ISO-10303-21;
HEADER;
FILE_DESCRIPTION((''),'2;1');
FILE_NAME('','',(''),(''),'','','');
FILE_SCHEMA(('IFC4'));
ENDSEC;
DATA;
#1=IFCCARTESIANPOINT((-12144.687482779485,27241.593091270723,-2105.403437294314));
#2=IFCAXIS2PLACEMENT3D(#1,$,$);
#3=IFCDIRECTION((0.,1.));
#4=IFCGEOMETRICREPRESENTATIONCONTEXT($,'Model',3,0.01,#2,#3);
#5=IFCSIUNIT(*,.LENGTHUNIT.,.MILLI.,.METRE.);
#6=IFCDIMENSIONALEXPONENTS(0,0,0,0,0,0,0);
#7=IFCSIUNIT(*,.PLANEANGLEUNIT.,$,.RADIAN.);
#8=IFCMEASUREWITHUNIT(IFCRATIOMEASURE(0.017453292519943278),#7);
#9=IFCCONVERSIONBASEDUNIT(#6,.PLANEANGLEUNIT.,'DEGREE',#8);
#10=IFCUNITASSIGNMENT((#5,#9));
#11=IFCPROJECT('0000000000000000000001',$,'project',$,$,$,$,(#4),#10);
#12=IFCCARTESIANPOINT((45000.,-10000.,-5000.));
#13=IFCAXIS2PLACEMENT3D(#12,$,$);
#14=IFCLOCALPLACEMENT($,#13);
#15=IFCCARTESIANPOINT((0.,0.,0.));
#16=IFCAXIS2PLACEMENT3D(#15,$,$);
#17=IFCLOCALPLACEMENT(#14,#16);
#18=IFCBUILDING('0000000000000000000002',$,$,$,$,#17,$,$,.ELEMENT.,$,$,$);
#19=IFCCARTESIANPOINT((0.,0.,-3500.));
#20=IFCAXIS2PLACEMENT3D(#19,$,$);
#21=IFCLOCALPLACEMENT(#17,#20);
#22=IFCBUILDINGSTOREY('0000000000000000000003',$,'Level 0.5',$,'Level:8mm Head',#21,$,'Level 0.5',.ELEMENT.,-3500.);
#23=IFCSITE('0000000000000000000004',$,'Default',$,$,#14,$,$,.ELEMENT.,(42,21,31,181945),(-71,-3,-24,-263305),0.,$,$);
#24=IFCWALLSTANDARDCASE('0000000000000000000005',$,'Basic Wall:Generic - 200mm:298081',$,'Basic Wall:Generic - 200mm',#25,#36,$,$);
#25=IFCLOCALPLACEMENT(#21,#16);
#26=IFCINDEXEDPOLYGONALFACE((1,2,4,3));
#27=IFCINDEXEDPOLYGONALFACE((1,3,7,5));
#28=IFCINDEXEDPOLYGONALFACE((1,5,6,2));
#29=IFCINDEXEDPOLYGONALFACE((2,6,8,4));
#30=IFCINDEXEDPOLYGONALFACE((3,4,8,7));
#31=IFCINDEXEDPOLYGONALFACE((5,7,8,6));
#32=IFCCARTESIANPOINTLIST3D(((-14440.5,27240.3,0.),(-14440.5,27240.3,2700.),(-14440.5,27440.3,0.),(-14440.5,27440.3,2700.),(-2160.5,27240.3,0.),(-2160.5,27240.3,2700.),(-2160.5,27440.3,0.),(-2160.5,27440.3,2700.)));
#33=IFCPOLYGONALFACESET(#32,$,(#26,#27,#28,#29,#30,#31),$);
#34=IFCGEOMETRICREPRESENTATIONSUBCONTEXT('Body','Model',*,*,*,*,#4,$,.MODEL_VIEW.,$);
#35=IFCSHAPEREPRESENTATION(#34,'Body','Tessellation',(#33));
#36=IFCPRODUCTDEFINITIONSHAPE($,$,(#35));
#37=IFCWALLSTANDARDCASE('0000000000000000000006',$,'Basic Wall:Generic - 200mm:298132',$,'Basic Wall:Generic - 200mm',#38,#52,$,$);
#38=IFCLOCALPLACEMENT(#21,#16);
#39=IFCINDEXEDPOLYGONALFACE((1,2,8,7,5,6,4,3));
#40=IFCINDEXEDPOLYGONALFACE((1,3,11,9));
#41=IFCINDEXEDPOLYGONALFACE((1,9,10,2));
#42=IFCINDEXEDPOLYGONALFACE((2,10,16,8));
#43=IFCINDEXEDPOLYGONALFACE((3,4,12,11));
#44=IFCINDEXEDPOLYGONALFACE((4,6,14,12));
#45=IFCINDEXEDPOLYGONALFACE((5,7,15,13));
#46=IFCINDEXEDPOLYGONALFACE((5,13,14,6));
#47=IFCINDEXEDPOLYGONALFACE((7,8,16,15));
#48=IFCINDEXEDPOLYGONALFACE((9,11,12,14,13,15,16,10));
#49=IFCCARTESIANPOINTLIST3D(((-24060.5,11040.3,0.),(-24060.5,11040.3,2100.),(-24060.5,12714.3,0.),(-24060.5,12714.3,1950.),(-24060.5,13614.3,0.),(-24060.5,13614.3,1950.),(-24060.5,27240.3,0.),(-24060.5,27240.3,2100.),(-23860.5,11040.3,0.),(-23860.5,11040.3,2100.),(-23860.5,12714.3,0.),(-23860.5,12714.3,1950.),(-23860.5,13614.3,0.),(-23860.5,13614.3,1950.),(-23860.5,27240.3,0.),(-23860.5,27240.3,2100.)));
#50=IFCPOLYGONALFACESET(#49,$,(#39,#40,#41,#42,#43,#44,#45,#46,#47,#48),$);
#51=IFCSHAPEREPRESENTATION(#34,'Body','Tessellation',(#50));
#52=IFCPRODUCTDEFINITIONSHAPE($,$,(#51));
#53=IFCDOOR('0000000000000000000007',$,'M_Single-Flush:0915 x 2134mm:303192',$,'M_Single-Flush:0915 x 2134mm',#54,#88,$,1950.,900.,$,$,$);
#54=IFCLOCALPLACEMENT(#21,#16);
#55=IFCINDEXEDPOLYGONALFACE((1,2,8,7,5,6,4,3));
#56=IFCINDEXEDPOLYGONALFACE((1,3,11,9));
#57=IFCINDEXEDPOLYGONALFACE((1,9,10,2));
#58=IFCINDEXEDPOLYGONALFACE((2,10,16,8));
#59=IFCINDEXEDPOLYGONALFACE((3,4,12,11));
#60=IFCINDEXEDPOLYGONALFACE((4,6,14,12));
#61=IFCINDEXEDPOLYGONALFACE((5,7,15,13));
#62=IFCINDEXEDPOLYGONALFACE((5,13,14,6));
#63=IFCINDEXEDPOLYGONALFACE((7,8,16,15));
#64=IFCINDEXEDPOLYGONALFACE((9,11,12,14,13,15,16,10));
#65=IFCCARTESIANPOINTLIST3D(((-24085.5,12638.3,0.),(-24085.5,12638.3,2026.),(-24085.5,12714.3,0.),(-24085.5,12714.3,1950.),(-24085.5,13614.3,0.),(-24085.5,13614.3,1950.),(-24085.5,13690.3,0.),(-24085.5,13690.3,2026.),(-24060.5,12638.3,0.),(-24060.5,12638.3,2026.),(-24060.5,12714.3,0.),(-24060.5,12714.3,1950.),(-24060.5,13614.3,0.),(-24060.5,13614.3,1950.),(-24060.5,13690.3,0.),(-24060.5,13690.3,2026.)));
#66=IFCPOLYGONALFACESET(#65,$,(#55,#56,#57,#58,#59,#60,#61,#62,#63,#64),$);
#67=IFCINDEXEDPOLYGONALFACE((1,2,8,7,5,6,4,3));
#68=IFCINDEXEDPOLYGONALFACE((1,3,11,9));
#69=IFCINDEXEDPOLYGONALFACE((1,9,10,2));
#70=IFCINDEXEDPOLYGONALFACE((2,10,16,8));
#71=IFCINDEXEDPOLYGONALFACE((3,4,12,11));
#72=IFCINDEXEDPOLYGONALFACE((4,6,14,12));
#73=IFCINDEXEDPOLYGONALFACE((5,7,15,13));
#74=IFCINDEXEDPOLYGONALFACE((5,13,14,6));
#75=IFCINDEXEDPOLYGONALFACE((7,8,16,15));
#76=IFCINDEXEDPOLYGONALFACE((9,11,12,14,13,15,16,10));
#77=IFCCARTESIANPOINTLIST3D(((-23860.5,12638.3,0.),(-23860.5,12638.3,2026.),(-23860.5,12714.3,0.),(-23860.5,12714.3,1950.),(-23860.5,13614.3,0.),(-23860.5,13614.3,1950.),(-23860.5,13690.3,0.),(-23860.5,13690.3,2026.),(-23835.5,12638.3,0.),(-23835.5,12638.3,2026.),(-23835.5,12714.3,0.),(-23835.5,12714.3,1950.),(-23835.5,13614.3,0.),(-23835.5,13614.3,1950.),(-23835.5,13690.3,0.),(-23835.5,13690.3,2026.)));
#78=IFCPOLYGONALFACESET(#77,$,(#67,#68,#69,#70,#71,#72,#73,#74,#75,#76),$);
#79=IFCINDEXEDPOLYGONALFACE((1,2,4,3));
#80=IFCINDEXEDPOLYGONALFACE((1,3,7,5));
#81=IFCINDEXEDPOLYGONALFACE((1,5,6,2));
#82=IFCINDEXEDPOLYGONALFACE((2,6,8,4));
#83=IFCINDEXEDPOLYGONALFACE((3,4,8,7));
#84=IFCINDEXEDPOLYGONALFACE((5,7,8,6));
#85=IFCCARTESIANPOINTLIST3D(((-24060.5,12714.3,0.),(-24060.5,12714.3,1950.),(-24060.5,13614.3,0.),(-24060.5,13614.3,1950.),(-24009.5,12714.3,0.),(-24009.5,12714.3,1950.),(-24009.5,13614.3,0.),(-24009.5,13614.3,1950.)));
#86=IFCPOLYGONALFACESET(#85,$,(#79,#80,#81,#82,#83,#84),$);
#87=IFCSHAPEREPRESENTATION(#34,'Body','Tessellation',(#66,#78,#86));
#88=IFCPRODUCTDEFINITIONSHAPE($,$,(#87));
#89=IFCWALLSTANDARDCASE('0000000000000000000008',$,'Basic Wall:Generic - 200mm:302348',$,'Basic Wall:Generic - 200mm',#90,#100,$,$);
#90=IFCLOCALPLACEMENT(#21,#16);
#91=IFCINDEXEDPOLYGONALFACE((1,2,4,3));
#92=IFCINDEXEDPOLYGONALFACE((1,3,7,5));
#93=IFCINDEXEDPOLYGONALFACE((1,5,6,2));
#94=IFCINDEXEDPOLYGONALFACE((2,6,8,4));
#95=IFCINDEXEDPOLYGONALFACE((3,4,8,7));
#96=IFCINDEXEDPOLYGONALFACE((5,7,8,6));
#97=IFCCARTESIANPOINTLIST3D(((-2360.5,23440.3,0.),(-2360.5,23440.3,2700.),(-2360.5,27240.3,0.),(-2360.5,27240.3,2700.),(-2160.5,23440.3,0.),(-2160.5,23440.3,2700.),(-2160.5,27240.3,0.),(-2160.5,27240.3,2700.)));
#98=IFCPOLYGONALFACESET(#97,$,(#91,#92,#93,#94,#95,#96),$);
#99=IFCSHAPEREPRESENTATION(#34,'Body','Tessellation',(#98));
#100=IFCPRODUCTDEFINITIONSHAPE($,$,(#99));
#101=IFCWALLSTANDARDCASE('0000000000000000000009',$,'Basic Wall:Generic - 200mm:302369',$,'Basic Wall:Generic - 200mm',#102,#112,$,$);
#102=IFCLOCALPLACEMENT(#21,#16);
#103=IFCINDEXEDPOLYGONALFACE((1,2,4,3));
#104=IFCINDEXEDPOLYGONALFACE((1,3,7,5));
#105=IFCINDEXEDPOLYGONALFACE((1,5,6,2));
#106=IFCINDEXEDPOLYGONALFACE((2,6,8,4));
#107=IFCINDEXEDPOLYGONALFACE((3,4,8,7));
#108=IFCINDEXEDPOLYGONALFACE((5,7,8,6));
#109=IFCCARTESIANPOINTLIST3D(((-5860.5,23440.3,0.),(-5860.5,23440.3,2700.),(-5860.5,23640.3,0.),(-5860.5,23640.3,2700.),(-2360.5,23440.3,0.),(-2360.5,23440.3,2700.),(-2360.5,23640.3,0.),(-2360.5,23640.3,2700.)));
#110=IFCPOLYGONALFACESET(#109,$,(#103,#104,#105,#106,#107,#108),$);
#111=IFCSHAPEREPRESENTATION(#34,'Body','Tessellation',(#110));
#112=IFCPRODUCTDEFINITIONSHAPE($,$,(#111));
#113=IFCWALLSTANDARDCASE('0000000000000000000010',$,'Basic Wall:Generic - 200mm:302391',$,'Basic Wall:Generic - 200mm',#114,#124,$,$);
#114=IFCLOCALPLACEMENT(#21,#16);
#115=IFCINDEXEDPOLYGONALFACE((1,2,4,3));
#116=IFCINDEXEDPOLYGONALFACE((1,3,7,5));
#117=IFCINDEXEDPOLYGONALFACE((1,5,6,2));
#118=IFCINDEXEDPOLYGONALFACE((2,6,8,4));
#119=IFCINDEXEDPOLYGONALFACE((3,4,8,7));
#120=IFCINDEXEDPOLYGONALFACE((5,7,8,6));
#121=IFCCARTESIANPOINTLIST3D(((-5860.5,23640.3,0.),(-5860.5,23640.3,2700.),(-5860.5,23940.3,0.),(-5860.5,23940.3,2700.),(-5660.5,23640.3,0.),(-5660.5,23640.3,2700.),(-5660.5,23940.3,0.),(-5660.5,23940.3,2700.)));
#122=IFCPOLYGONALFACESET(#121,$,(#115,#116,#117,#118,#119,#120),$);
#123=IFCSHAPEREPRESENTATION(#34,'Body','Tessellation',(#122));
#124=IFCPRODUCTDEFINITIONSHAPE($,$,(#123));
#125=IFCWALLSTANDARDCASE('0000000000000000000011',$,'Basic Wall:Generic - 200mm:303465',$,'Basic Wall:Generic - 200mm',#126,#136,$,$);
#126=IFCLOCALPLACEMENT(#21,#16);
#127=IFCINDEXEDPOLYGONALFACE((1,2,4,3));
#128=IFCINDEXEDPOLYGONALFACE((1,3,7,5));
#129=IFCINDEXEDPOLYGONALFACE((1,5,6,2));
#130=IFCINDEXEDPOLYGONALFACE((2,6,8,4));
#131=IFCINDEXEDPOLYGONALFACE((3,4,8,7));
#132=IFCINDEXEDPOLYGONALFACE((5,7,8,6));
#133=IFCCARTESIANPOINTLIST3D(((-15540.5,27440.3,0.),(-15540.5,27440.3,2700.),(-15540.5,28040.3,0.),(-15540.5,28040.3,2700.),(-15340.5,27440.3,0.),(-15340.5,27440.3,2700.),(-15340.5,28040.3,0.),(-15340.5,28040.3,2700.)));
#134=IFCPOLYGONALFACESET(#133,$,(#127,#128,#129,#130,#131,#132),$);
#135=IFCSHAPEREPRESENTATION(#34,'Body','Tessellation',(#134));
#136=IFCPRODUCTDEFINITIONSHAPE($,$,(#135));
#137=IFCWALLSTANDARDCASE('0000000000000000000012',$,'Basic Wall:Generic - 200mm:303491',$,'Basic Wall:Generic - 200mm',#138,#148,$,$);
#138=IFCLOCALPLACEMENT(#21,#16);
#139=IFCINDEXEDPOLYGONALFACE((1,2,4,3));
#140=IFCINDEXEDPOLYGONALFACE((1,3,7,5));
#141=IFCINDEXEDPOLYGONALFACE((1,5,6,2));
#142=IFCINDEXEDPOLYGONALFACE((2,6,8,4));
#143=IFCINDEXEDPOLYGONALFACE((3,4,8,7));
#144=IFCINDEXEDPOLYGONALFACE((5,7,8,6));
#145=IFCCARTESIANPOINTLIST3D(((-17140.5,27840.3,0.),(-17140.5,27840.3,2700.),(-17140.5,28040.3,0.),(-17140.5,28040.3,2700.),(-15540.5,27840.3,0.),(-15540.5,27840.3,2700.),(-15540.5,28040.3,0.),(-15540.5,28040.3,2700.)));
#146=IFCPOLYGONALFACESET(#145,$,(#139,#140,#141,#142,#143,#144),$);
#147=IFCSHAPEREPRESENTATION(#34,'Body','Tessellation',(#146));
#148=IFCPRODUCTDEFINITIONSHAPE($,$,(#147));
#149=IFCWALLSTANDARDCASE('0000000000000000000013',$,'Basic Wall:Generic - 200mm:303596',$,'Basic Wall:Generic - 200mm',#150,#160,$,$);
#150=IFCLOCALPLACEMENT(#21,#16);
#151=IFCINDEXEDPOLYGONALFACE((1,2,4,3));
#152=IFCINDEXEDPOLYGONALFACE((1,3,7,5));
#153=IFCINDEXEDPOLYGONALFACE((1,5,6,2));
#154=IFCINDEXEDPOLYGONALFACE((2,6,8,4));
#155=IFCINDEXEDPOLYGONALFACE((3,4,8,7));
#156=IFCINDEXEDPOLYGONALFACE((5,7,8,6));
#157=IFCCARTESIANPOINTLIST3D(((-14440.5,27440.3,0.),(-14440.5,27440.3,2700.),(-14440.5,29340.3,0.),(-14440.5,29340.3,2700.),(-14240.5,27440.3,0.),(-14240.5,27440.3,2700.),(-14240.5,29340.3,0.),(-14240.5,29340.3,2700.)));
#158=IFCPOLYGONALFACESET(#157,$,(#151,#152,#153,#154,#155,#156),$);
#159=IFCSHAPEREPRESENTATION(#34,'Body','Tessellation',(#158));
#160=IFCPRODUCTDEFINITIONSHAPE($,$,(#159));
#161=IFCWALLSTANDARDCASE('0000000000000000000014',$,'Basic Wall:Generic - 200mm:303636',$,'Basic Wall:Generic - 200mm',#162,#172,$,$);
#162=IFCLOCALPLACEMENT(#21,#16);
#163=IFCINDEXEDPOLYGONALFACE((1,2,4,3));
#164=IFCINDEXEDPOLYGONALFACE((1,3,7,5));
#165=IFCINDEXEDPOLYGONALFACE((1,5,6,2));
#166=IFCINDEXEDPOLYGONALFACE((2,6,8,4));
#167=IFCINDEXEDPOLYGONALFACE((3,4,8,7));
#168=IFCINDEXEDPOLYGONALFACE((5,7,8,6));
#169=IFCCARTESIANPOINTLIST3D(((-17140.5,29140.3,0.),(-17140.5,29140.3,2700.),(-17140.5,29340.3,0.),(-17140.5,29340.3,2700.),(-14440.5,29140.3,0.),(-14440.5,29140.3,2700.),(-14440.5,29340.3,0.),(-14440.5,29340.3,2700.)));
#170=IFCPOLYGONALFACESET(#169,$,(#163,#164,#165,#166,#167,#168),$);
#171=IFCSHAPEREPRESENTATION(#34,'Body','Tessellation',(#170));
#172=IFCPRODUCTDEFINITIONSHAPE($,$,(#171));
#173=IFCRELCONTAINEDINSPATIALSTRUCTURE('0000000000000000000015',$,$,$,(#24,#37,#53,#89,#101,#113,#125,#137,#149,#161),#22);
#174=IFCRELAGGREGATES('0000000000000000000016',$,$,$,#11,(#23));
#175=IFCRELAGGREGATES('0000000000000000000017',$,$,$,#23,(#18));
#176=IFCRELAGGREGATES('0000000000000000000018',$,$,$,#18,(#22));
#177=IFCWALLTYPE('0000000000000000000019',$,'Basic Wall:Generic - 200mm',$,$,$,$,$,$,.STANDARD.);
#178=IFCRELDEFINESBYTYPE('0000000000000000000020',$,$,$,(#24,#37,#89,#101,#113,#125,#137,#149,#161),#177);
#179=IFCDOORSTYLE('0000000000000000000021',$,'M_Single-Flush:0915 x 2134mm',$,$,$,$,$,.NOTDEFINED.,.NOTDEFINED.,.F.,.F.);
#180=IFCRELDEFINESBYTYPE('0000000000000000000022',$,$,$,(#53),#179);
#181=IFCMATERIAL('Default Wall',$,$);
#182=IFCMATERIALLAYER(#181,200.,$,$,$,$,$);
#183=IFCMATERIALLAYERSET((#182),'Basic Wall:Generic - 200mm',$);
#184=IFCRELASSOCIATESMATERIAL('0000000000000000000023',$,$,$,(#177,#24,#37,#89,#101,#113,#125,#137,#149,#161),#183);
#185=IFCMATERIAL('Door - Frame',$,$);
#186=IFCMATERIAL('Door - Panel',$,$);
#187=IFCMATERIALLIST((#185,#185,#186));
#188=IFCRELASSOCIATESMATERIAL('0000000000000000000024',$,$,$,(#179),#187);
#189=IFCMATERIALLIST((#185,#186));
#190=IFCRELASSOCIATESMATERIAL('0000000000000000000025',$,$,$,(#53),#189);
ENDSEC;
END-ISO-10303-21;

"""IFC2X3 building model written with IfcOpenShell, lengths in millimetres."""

from ifc_helpers import new_model, entity, si_unit, converted_unit, direction, frame, frame_2d, origin, place, context, subcontext, project, spatial, polyline, rectangle, outline, extrude, clip, bounded_halfspace, source, transform, mapped, material, material_list, layer, layer_set, layer_usage, type_object, type_shapes, element, fill, save


model = new_model("IFC2X3")

# Units and contexts
model_context = context("Model", 3, precision=0.01, world=frame((-12144.687482779485, 27241.593091270723, -2105.403437294314)), true_north=direction((0.0, 1.0)))
body_context = subcontext(model_context, "Body", "Model", "MODEL_VIEW")
ifc_project = project(units=[si_unit("LENGTHUNIT", "METRE", prefix="MILLI"), converted_unit("PLANEANGLEUNIT", "DEGREE", entity("IfcRatioMeasure", 0.017453292519943278), si_unit("PLANEANGLEUNIT", "RADIAN"), dimensions=[0, 0, 0, 0, 0, 0, 0])], contexts=[model_context])

# Site, building, storey
site_placement = place(None, frame((45000.0, -10000.0, -5000.0)))
site = spatial("IfcSite", under=ifc_project, at=site_placement, Name="Default", CompositionType="ELEMENT", RefLatitude=(42, 21, 31, 181945), RefLongitude=(-71, -3, -24, -263305), RefElevation=0.0)
building_placement = place(site_placement, origin())
building = spatial("IfcBuilding", under=site, at=building_placement, CompositionType="ELEMENT")
storey_placement = place(building_placement, frame((0.0, 0.0, -3500.0)))
storey = spatial("IfcBuildingStorey", under=building, at=storey_placement, Name="Level 0.5", ObjectType="Level:8mm Head", LongName="Level 0.5", CompositionType="ELEMENT", Elevation=-3500.0)

# Wall
ifc_material_1 = material(Name="Default Wall")
ifc_layer_1 = layer(ifc_material_1, 200.0)
ifc_layer_set_1 = layer_set([ifc_layer_1], Name="Basic Wall:Generic - 200mm")
wall_type_1 = type_object("IfcWallType", Name="Basic Wall:Generic - 200mm", PredefinedType="STANDARD", material=ifc_layer_set_1)
ifc_layer_usage_1 = layer_usage(ifc_layer_set_1, "AXIS2", "NEGATIVE", 100.0)
wall_1_placement = place(storey_placement, frame((-2160.5, 27340.3, 0.0), z_axis=(0.0, 0.0, 1.0), x_axis=(-1.0, 0.0, 0.0)))
element("IfcWallStandardCase", 1, at=wall_1_placement, inside=storey, type_object=wall_type_1, material=ifc_layer_usage_1, Name="Basic Wall:Generic - 200mm:298081", ObjectType="Basic Wall:Generic - 200mm", context=body_context, shape_type="SweptSolid", body=[
    extrude(rectangle(XDim=12280.0, YDim=200.0, at=frame_2d((6140.0, 0.0), x_axis=(-1.0, 0.0))), origin(), (0.0, 0.0, 1.0), 2700.0),
])

# Wall, opening, door
ifc_layer_usage_2 = layer_usage(ifc_layer_set_1, "AXIS2", "NEGATIVE", 100.0)
wall_2_placement = place(storey_placement, frame((-23960.5, 27240.3, 0.0), z_axis=(0.0, 0.0, 1.0), x_axis=(0.0, -1.0, 0.0)))
wall_2 = element("IfcWallStandardCase", 2, at=wall_2_placement, inside=storey, type_object=wall_type_1, material=ifc_layer_usage_2, Name="Basic Wall:Generic - 200mm:298132", ObjectType="Basic Wall:Generic - 200mm", context=body_context, shape_type="Clipping", body=[
    clip(extrude(rectangle(XDim=16200.0, YDim=200.0, at=frame_2d((8100.0, 0.0), x_axis=(1.0, 0.0))), origin(), (0.0, 0.0, 1.0), 2100.0), bounded_halfspace(frame((0.0, -100.0, 2100.0), z_axis=(0.0, 0.0, -1.0), x_axis=(1.0, 0.0, 0.0)), True, frame((0.0, -100.0, 2100.0)), polyline([(0.0, 0.0), (4884716.1, 0.0), (4937760.0, 0.0), (4937760.0, 60960.0), (0.0, 60960.0), (0.0, 0.0)]))),
])
opening_1_placement = place(wall_2_placement, frame((14526.0, 100.0, 0.0)))
opening_1 = element("IfcOpeningElement", 3, at=opening_1_placement, cuts=wall_2, ObjectType="Opening", context=body_context, shape_type="SweptSolid", body=[
    extrude(rectangle(XDim=900.0, YDim=1950.0, at=frame_2d((975.0, 450.0), x_axis=(0.0, -1.0))), frame((0.0, 0.0, 0.0), z_axis=(0.0, -1.0, 0.0), x_axis=(0.0, 0.0, 1.0)), (0.0, 0.0, 1.0), 200.0),
])
ifc_material_2 = material(Name="Door - Frame")
ifc_material_3 = material(Name="Door - Panel")
ifc_material_list_1 = material_list([ifc_material_2, ifc_material_3])
ifc_material_list_2 = material_list([ifc_material_2, ifc_material_2, ifc_material_3])
door_style = type_object("IfcDoorStyle", Name="M_Single-Flush:0915 x 2134mm", ConstructionType="NOTDEFINED", OperationType="NOTDEFINED", ParameterTakesPrecedence=False, Sizeable=False, material=ifc_material_list_2)
shared_shape_1 = source(origin(), body_context, "Body", "SweptSolid", [
    extrude(outline(polyline([(-526.0, -1032.0), (526.0, -1032.0), (526.0, 994.0), (450.0, 994.0), (450.0, -956.0), (-450.0, -956.0), (-450.0, 994.0), (-526.0, 994.0), (-526.0, -1032.0)])), frame((450.0, 225.0, 994.0), z_axis=(0.0, -1.0, 0.0), x_axis=(-1.0, 0.0, 0.0)), (0.0, 0.0, 1.0), 25.0),
    extrude(outline(polyline([(-1032.0, -526.0), (994.0, -526.0), (994.0, -450.0), (-956.0, -450.0), (-956.0, 450.0), (994.0, 450.0), (994.0, 526.0), (-1032.0, 526.0), (-1032.0, -526.0)])), frame((450.0, 0.0, 994.0), z_axis=(0.0, -1.0, 0.0), x_axis=(0.0, 0.0, -1.0)), (0.0, 0.0, 1.0), 25.0),
    extrude(rectangle(XDim=900.0, YDim=51.0, at=frame_2d((0.0, 0.0), x_axis=(1.0, 0.0))), frame((450.0, 174.5, 0.0)), (0.0, 0.0, 1.0), 1950.0),
])
type_shapes(door_style, [shared_shape_1])
door_placement = place(opening_1_placement, frame((0.0, 0.0, 0.0), z_axis=(0.0, 0.0, 1.0), x_axis=(-1.0, 0.0, 0.0)))
door = element("IfcDoor", 4, at=door_placement, inside=storey, type_object=door_style, material=ifc_material_list_1, Name="M_Single-Flush:0915 x 2134mm:303192", ObjectType="M_Single-Flush:0915 x 2134mm", OverallHeight=1950.0, OverallWidth=900.0, context=body_context, shape_type="MappedRepresentation", body=[
    mapped(shared_shape_1, transform((0.0, 0.0, 0.0), scale=1.0)),
])
fill(opening_1, door)

# Walls
ifc_layer_usage_3 = layer_usage(ifc_layer_set_1, "AXIS2", "NEGATIVE", 100.0)
wall_3_placement = place(storey_placement, frame((-2260.5, 27240.3, 0.0), z_axis=(0.0, 0.0, 1.0), x_axis=(0.0, -1.0, 0.0)))
element("IfcWallStandardCase", 5, at=wall_3_placement, inside=storey, type_object=wall_type_1, material=ifc_layer_usage_3, Name="Basic Wall:Generic - 200mm:302348", ObjectType="Basic Wall:Generic - 200mm", context=body_context, shape_type="SweptSolid", body=[
    extrude(rectangle(XDim=3800.0, YDim=200.0, at=frame_2d((1900.0, 0.0), x_axis=(-1.0, 0.0))), origin(), (0.0, 0.0, 1.0), 2700.0),
])
ifc_layer_usage_4 = layer_usage(ifc_layer_set_1, "AXIS2", "NEGATIVE", 100.0)
wall_4_placement = place(storey_placement, frame((-2360.5, 23540.3, 0.0), z_axis=(0.0, 0.0, 1.0), x_axis=(-1.0, 0.0, 0.0)))
element("IfcWallStandardCase", 6, at=wall_4_placement, inside=storey, type_object=wall_type_1, material=ifc_layer_usage_4, Name="Basic Wall:Generic - 200mm:302369", ObjectType="Basic Wall:Generic - 200mm", context=body_context, shape_type="SweptSolid", body=[
    extrude(rectangle(XDim=3500.0, YDim=200.0, at=frame_2d((1750.0, 0.0), x_axis=(-1.0, 0.0))), origin(), (0.0, 0.0, 1.0), 2700.0),
])
ifc_layer_usage_5 = layer_usage(ifc_layer_set_1, "AXIS2", "NEGATIVE", 100.0)
wall_5_placement = place(storey_placement, frame((-5760.5, 23640.3, 0.0), z_axis=(0.0, 0.0, 1.0), x_axis=(0.0, 1.0, 0.0)))
element("IfcWallStandardCase", 7, at=wall_5_placement, inside=storey, type_object=wall_type_1, material=ifc_layer_usage_5, Name="Basic Wall:Generic - 200mm:302391", ObjectType="Basic Wall:Generic - 200mm", context=body_context, shape_type="SweptSolid", body=[
    extrude(rectangle(XDim=300.0, YDim=200.0, at=frame_2d((150.0, 0.0), x_axis=(-1.0, 0.0))), origin(), (0.0, 0.0, 1.0), 2700.0),
])
ifc_layer_usage_6 = layer_usage(ifc_layer_set_1, "AXIS2", "NEGATIVE", 100.0)
wall_6_placement = place(storey_placement, frame((-15440.5, 27440.3, 0.0), z_axis=(0.0, 0.0, 1.0), x_axis=(0.0, 1.0, 0.0)))
element("IfcWallStandardCase", 8, at=wall_6_placement, inside=storey, type_object=wall_type_1, material=ifc_layer_usage_6, Name="Basic Wall:Generic - 200mm:303465", ObjectType="Basic Wall:Generic - 200mm", context=body_context, shape_type="SweptSolid", body=[
    extrude(rectangle(XDim=600.0, YDim=200.0, at=frame_2d((300.0, 0.0), x_axis=(-1.0, 0.0))), origin(), (0.0, 0.0, 1.0), 2700.0),
])
ifc_layer_usage_7 = layer_usage(ifc_layer_set_1, "AXIS2", "NEGATIVE", 100.0)
wall_7_placement = place(storey_placement, frame((-15540.5, 27940.3, 0.0), z_axis=(0.0, 0.0, 1.0), x_axis=(-1.0, 0.0, 0.0)))
element("IfcWallStandardCase", 9, at=wall_7_placement, inside=storey, type_object=wall_type_1, material=ifc_layer_usage_7, Name="Basic Wall:Generic - 200mm:303491", ObjectType="Basic Wall:Generic - 200mm", context=body_context, shape_type="SweptSolid", body=[
    extrude(rectangle(XDim=1600.0, YDim=200.0, at=frame_2d((800.0, 0.0), x_axis=(-1.0, 0.0))), origin(), (0.0, 0.0, 1.0), 2700.0),
])
ifc_layer_usage_8 = layer_usage(ifc_layer_set_1, "AXIS2", "NEGATIVE", 100.0)
wall_8_placement = place(storey_placement, frame((-14340.5, 27440.3, 0.0), z_axis=(0.0, 0.0, 1.0), x_axis=(0.0, 1.0, 0.0)))
element("IfcWallStandardCase", 10, at=wall_8_placement, inside=storey, type_object=wall_type_1, material=ifc_layer_usage_8, Name="Basic Wall:Generic - 200mm:303596", ObjectType="Basic Wall:Generic - 200mm", context=body_context, shape_type="SweptSolid", body=[
    extrude(rectangle(XDim=1900.0, YDim=200.0, at=frame_2d((950.0, 0.0), x_axis=(-1.0, 0.0))), origin(), (0.0, 0.0, 1.0), 2700.0),
])
ifc_layer_usage_9 = layer_usage(ifc_layer_set_1, "AXIS2", "NEGATIVE", 100.0)
wall_9_placement = place(storey_placement, frame((-14440.5, 29240.3, 0.0), z_axis=(0.0, 0.0, 1.0), x_axis=(-1.0, 0.0, 0.0)))
element("IfcWallStandardCase", 11, at=wall_9_placement, inside=storey, type_object=wall_type_1, material=ifc_layer_usage_9, Name="Basic Wall:Generic - 200mm:303636", ObjectType="Basic Wall:Generic - 200mm", context=body_context, shape_type="SweptSolid", body=[
    extrude(rectangle(XDim=2700.0, YDim=200.0, at=frame_2d((1350.0, 0.0), x_axis=(-1.0, 0.0))), origin(), (0.0, 0.0, 1.0), 2700.0),
])

save(model, "model.ifc")
